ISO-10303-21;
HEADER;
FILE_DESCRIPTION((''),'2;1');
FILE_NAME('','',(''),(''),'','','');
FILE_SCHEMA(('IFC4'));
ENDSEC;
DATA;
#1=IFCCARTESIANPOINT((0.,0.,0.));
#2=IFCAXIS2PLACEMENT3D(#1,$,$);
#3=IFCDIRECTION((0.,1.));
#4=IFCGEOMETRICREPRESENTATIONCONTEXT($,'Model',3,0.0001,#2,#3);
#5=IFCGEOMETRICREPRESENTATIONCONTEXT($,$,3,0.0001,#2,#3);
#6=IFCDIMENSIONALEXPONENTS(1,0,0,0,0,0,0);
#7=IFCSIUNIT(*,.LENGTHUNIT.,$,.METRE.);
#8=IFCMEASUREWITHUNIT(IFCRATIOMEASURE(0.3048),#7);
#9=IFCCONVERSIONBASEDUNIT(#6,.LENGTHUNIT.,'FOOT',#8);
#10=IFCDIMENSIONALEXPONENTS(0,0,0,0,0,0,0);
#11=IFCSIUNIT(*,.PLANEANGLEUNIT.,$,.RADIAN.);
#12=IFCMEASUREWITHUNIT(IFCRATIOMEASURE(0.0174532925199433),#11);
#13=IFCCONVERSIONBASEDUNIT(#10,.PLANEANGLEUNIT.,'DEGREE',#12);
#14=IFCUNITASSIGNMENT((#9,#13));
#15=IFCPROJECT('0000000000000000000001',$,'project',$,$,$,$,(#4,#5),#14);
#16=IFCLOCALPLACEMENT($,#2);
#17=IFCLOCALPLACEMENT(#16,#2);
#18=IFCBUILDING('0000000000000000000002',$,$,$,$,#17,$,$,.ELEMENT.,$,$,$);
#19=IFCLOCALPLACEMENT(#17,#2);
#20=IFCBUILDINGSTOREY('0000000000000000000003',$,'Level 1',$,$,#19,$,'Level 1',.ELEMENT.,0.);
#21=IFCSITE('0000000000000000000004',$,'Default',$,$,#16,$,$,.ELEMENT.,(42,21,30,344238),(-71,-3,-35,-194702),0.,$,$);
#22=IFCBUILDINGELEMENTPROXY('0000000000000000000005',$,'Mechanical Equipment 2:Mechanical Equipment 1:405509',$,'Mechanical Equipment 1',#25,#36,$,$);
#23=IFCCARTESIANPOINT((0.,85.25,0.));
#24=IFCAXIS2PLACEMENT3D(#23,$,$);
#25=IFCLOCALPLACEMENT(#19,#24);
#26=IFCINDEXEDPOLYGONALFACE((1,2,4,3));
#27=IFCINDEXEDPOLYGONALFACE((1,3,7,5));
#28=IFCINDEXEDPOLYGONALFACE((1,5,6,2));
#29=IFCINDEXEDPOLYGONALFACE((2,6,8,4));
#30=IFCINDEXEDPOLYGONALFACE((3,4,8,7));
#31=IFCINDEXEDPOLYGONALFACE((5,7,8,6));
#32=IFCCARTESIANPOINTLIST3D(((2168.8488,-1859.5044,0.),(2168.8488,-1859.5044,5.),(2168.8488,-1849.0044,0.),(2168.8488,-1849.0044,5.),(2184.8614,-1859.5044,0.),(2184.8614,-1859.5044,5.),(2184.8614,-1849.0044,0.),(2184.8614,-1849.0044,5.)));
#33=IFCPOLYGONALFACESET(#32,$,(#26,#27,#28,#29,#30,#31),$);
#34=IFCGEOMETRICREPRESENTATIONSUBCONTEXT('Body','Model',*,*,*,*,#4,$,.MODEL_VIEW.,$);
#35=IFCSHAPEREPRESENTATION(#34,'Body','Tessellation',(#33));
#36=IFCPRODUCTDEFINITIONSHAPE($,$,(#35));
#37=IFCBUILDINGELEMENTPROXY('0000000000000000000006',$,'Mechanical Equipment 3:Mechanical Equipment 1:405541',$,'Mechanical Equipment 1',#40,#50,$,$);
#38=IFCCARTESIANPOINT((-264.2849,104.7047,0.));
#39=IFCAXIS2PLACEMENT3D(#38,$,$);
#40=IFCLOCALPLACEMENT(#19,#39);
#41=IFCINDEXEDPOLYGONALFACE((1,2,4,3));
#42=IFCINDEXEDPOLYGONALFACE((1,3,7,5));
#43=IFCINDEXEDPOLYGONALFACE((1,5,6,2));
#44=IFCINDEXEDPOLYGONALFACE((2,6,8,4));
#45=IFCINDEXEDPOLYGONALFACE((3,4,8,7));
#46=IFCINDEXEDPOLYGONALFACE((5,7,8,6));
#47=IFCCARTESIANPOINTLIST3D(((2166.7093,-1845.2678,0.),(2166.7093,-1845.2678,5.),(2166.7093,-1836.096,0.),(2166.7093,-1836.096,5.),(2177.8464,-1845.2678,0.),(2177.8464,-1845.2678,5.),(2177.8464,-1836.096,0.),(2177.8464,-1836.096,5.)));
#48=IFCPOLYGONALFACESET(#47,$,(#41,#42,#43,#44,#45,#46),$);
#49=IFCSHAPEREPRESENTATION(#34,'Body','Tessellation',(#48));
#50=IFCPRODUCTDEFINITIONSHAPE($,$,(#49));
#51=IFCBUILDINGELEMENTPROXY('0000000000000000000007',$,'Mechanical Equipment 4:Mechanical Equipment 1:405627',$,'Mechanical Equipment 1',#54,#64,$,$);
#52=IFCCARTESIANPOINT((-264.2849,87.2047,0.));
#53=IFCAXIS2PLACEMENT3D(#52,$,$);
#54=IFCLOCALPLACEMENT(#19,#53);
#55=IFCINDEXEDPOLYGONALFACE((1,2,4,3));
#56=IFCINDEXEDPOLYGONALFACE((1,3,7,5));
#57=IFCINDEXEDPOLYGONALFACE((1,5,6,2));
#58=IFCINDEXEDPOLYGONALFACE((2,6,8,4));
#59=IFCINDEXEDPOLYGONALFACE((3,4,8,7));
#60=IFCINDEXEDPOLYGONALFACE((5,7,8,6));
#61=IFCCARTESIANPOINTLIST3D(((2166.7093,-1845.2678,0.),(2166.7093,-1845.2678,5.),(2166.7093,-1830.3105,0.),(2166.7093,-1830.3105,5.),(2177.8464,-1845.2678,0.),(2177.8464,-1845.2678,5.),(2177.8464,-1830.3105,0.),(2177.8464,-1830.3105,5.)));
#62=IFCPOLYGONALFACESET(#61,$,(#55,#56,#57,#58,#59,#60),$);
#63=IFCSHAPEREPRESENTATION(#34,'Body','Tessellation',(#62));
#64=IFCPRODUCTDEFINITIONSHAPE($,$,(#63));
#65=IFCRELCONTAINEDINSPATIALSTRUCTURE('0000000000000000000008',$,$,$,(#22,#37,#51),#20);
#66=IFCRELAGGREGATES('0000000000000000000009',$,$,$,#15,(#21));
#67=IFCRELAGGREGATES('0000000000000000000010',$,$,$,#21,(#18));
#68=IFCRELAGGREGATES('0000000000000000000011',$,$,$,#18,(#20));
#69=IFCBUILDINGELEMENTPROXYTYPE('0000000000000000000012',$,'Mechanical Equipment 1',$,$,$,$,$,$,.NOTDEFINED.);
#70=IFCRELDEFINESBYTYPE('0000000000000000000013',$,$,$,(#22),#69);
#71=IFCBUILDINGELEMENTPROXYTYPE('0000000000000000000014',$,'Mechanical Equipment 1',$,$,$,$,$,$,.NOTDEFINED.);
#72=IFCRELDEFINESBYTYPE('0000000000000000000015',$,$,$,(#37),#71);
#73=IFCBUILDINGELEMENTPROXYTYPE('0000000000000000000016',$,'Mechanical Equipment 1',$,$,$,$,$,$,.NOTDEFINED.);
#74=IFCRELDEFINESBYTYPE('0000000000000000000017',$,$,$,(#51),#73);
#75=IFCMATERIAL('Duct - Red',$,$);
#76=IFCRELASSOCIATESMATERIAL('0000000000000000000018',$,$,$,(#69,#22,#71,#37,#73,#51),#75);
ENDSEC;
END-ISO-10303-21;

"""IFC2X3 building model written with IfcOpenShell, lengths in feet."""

from ifc_helpers import new_model, entity, si_unit, converted_unit, direction, frame, frame_2d, origin, origin_2d_with_axis, place, context, subcontext, project, spatial, rectangle, extrude, source, transform, mapped, material, type_object, type_shapes, element, save


model = new_model("IFC2X3")

# Units and contexts
model_context = context("Model", 3, precision=0.0001, world=origin(), true_north=direction((0.0, 1.0)))
context_of_model = context(None, 3, precision=0.0001, world=origin(), true_north=direction((0.0, 1.0)))
body_context = subcontext(model_context, "Body", "Model", "MODEL_VIEW")
ifc_project = project(units=[converted_unit("LENGTHUNIT", "FOOT", entity("IfcRatioMeasure", 0.3048), si_unit("LENGTHUNIT", "METRE"), dimensions=[1, 0, 0, 0, 0, 0, 0]), converted_unit("PLANEANGLEUNIT", "DEGREE", entity("IfcRatioMeasure", 0.0174532925199433), si_unit("PLANEANGLEUNIT", "RADIAN"), dimensions=[0, 0, 0, 0, 0, 0, 0])], contexts=[model_context, context_of_model])

# Site, building, storey
site_placement = place(None, origin())
site = spatial("IfcSite", under=ifc_project, at=site_placement, Name="Default", CompositionType="ELEMENT", RefLatitude=(42, 21, 30, 344238), RefLongitude=(-71, -3, -35, -194702), RefElevation=0.0)
building_placement = place(site_placement, origin())
building = spatial("IfcBuilding", under=site, at=building_placement, CompositionType="ELEMENT")
storey_placement = place(building_placement, origin())
storey = spatial("IfcBuildingStorey", under=building, at=storey_placement, Name="Level 1", LongName="Level 1", CompositionType="ELEMENT", Elevation=0.0)

# Shared definitions
ifc_material_1 = material(Name="Duct - Red")

# Building element proxies
building_element_proxy_type_1 = type_object("IfcBuildingElementProxyType", Name="Mechanical Equipment 1", PredefinedType="NOTDEFINED", material=ifc_material_1)
shared_shape_1 = source(origin(), body_context, "Body", "SweptSolid", [
    extrude(rectangle(XDim=16.0126, YDim=10.5, at=origin_2d_with_axis()), frame((2176.8551, -1854.2544, 0.0), z_axis=(0.0, 0.0, 1.0), x_axis=(-1.0, 0.0, 0.0)), (0.0, 0.0, 1.0), 5.0),
])
type_shapes(building_element_proxy_type_1, [shared_shape_1])
proxy_1_placement = place(storey_placement, frame((0.0, 85.25, 0.0)))
element("IfcBuildingElementProxy", 1, at=proxy_1_placement, inside=storey, type_object=building_element_proxy_type_1, material=ifc_material_1, Name="Mechanical Equipment 2:Mechanical Equipment 1:405509", ObjectType="Mechanical Equipment 1", context=body_context, shape_type="MappedRepresentation", body=[
    mapped(shared_shape_1, transform((0.0, 0.0, 0.0), scale=1.0)),
])
building_element_proxy_type_2 = type_object("IfcBuildingElementProxyType", Name="Mechanical Equipment 1", PredefinedType="NOTDEFINED", material=ifc_material_1)
shared_shape_2 = source(origin(), body_context, "Body", "SweptSolid", [
    extrude(rectangle(XDim=11.1372, YDim=9.1718, at=frame_2d((0.0, 0.0), x_axis=(1.0, 0.0))), frame((2172.2779, -1840.6819, 0.0), z_axis=(0.0, 0.0, 1.0), x_axis=(-1.0, 0.0, 0.0)), (0.0, 0.0, 1.0), 5.0),
])
type_shapes(building_element_proxy_type_2, [shared_shape_2])
proxy_2_placement = place(storey_placement, frame((-264.2849, 104.7047, 0.0)))
element("IfcBuildingElementProxy", 2, at=proxy_2_placement, inside=storey, type_object=building_element_proxy_type_2, material=ifc_material_1, Name="Mechanical Equipment 3:Mechanical Equipment 1:405541", ObjectType="Mechanical Equipment 1", context=body_context, shape_type="MappedRepresentation", body=[
    mapped(shared_shape_2, transform((0.0, 0.0, 0.0), scale=1.0)),
])
building_element_proxy_type_3 = type_object("IfcBuildingElementProxyType", Name="Mechanical Equipment 1", PredefinedType="NOTDEFINED", material=ifc_material_1)
shared_shape_3 = source(origin(), body_context, "Body", "SweptSolid", [
    extrude(rectangle(XDim=11.1372, YDim=14.9573, at=frame_2d((0.0, 0.0), x_axis=(1.0, 0.0))), frame((2172.2779, -1837.7892, 0.0), z_axis=(0.0, 0.0, 1.0), x_axis=(-1.0, 0.0, 0.0)), (0.0, 0.0, 1.0), 5.0),
])
type_shapes(building_element_proxy_type_3, [shared_shape_3])
proxy_3_placement = place(storey_placement, frame((-264.2849, 87.2047, 0.0)))
element("IfcBuildingElementProxy", 3, at=proxy_3_placement, inside=storey, type_object=building_element_proxy_type_3, material=ifc_material_1, Name="Mechanical Equipment 4:Mechanical Equipment 1:405627", ObjectType="Mechanical Equipment 1", context=body_context, shape_type="MappedRepresentation", body=[
    mapped(shared_shape_3, transform((0.0, 0.0, 0.0), scale=1.0)),
])

save(model, "model.ifc")
